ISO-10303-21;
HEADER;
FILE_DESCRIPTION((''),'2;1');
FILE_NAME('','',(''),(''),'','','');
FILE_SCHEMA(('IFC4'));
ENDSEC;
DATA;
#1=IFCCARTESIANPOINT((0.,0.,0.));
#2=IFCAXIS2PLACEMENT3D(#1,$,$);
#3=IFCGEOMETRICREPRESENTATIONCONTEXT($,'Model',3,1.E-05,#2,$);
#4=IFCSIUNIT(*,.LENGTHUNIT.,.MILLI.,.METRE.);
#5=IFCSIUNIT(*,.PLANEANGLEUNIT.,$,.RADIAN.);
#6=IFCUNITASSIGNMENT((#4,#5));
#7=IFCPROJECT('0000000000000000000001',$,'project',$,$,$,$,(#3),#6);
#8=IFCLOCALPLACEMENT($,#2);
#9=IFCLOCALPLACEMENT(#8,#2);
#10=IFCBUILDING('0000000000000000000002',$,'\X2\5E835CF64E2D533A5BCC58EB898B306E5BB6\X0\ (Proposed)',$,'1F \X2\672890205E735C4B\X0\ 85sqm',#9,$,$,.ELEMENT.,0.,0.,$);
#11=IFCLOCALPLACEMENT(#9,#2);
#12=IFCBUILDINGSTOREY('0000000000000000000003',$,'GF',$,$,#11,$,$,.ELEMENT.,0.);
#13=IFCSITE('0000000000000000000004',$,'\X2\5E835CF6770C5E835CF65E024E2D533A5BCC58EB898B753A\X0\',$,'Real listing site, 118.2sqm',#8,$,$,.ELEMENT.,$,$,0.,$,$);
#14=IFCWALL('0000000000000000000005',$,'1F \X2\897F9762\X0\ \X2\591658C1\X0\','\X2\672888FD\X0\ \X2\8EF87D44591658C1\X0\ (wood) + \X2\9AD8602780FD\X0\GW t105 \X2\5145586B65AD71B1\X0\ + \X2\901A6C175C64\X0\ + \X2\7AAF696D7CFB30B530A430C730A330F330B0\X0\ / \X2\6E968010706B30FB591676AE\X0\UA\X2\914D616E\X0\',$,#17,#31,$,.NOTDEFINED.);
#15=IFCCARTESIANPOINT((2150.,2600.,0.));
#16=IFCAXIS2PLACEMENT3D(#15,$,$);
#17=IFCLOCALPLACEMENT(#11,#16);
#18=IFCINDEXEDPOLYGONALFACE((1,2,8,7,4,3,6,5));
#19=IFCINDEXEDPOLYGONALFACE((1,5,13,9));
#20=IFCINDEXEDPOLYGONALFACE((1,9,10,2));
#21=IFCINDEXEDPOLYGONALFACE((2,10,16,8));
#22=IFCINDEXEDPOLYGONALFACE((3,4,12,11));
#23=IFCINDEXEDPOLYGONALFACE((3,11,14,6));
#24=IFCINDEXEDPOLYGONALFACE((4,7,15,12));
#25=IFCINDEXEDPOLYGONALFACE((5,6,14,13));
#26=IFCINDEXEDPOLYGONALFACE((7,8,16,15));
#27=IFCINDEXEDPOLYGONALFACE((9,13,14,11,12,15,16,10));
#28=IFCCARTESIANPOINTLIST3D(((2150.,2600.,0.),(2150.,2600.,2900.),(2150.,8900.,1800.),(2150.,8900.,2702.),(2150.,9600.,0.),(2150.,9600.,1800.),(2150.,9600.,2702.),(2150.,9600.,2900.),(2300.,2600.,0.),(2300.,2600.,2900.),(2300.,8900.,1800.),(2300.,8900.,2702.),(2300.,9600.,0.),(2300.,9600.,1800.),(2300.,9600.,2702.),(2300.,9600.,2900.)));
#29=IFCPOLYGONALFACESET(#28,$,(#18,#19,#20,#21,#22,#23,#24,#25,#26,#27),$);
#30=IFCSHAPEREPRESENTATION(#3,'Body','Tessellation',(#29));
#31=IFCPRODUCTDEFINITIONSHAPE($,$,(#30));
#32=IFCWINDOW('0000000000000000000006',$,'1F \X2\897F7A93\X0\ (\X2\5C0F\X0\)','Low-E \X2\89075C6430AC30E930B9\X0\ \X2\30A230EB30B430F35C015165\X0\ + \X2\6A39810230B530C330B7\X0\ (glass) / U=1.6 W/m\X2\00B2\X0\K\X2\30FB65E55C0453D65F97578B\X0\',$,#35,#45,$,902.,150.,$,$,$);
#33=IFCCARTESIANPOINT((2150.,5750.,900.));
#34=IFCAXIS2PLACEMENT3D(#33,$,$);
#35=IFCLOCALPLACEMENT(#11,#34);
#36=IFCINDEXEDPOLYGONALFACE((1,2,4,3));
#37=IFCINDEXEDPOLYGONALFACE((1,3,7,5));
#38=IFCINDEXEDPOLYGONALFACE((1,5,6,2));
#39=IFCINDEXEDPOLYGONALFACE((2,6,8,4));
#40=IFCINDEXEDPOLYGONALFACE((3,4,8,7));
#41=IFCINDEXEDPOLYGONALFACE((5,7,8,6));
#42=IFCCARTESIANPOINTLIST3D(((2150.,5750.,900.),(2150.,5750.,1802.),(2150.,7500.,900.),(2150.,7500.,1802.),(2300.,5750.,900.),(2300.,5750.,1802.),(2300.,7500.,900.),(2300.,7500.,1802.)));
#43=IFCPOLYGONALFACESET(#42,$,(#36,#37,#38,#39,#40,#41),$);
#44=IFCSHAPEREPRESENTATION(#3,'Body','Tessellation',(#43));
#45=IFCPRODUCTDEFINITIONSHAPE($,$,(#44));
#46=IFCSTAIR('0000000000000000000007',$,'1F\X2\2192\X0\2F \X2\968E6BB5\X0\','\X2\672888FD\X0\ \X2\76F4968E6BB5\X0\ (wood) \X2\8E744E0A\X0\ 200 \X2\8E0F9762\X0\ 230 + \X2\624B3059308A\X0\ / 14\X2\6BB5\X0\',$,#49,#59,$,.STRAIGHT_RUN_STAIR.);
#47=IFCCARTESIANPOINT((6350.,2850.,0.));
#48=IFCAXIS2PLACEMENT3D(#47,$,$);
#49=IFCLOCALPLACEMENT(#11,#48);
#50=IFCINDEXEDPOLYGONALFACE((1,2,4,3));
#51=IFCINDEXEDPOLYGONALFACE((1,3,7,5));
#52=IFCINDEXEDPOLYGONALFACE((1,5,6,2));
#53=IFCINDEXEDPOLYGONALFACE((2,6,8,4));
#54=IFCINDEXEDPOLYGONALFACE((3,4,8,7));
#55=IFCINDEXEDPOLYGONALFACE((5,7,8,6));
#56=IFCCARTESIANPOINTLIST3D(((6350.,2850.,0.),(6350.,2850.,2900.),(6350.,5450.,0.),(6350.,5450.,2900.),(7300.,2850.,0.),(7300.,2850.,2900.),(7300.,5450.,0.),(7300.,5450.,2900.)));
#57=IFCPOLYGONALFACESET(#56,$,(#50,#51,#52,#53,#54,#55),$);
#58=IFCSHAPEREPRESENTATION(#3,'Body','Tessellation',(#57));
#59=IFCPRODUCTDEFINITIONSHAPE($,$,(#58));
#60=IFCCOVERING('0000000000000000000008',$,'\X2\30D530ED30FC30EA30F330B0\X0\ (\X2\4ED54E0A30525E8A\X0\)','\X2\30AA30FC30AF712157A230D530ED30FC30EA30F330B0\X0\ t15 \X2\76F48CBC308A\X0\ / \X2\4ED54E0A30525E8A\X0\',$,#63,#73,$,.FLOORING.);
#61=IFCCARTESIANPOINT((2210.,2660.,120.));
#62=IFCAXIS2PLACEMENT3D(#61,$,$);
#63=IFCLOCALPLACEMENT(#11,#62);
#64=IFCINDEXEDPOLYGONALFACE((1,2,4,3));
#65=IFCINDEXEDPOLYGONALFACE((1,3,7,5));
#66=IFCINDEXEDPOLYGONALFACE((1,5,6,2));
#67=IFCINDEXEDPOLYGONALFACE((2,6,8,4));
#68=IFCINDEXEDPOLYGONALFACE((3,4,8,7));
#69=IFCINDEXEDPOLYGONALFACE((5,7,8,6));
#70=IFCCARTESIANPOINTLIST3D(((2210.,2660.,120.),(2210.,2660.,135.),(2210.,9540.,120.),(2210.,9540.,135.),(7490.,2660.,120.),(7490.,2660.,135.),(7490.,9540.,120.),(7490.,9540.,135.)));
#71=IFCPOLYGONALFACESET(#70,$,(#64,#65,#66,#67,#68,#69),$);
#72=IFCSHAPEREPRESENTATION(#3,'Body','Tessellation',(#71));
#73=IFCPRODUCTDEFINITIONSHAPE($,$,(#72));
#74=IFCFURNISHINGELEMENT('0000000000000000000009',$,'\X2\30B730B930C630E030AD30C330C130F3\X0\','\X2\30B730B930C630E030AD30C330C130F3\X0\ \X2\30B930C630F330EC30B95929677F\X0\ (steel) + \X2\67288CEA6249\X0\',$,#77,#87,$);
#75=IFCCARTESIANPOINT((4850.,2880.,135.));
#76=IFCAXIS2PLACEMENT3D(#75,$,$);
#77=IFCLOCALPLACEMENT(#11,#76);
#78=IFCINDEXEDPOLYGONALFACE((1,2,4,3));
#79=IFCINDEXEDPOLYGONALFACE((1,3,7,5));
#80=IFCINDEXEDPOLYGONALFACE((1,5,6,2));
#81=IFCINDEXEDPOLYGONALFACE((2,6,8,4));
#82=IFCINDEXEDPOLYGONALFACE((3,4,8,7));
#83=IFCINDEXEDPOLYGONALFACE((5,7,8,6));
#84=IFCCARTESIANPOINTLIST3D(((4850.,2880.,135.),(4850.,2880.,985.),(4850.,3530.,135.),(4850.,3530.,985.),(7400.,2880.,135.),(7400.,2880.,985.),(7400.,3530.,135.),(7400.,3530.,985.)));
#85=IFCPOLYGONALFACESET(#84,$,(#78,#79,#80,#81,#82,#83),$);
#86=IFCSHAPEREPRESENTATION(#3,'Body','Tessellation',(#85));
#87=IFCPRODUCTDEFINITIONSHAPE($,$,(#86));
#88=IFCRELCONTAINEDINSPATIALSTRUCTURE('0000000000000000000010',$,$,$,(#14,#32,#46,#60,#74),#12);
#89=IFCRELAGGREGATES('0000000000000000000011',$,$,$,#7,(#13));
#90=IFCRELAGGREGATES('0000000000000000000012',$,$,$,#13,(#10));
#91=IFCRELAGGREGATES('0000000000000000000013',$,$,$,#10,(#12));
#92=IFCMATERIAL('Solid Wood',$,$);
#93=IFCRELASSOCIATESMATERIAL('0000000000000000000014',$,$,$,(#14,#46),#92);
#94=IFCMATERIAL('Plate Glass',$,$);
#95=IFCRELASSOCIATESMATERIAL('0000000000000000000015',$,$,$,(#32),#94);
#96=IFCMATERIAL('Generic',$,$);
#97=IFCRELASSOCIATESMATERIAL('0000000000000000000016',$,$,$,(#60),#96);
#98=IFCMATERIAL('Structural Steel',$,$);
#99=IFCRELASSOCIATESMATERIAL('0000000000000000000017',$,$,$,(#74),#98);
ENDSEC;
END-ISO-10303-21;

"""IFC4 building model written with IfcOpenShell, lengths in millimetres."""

from ifc_helpers import new_model, si_unit, frame, frame_2d, origin, place, context, project, spatial, rectangle, extrude, material, element, fill, save


model = new_model("IFC4")

# Units and contexts
model_context = context("Model", 3, precision=1e-05, world=origin())
ifc_project = project(units=[si_unit("LENGTHUNIT", "METRE", prefix="MILLI"), si_unit("PLANEANGLEUNIT", "RADIAN")], contexts=[model_context])

# Site, building, storey
site_placement = place(None, origin())
site = spatial("IfcSite", under=ifc_project, at=site_placement, Name="広島県広島市中区富士見町", ObjectType="Real listing site, 118.2sqm", CompositionType="ELEMENT", RefElevation=0.0)
building_placement = place(site_placement, origin())
building = spatial("IfcBuilding", under=site, at=building_placement, Name="広島中区富士見の家 (Proposed)", ObjectType="1F 木造平屋 85sqm", CompositionType="ELEMENT", ElevationOfRefHeight=0.0, ElevationOfTerrain=0.0)
storey_placement = place(building_placement, origin())
storey = spatial("IfcBuildingStorey", under=building, at=storey_placement, Name="GF", CompositionType="ELEMENT", Elevation=0.0)

# Shared definitions
ifc_material_1 = material(Name="Solid Wood")
ifc_material_2 = material(Name="Generic")

# Shared definitions
ifc_material_3 = material(Name="Plate Glass")

# Wall, opening, window
wall_1_placement = place(storey_placement, frame((2150.0, 2600.0, 0.0)))
wall_1 = element("IfcWall", 1, at=wall_1_placement, inside=storey, material=ifc_material_1, Name="1F 西面 外壁", Description="木製 軸組外壁 (wood) + 高性能GW t105 充填断熱 + 通気層 + 窯業系サイディング / 準耐火・外皮UA配慮", PredefinedType="NOTDEFINED", context=model_context, shape_type="SweptSolid", body=[
    extrude(rectangle(XDim=150.0, YDim=7000.0, at=frame_2d((75.0, 3500.0))), frame((2150.0, 2600.0, 0.0)), (0.0, 0.0, 1.0), 2900.0),
])
opening_1_placement = place(storey_placement, frame((2150.0, 5750.0, 900.0)))
opening_1 = element("IfcOpeningElement", 2, at=opening_1_placement, cuts=wall_1, PredefinedType="NOTDEFINED", context=model_context, shape_type="SweptSolid", body=[
    extrude(rectangle(XDim=150.0, YDim=1750.0, at=frame_2d((75.0, 875.0))), frame((2150.0, 5750.0, 900.0)), (0.0, 0.0, 1.0), 902.0),
])
window_1_placement = place(storey_placement, frame((2150.0, 5750.0, 900.0)))
window_1 = element("IfcWindow", 3, at=window_1_placement, inside=storey, material=ifc_material_3, Name="1F 西窓 (小)", Description="Low-E 複層ガラス アルゴン封入 + 樹脂サッシ (glass) / U=1.6 W/m²K・日射取得型", OverallHeight=902.0, OverallWidth=150.0, context=model_context, shape_type="SweptSolid", body=[
    extrude(rectangle(XDim=150.0, YDim=1750.0, at=frame_2d((75.0, 875.0))), frame((2150.0, 5750.0, 900.0)), (0.0, 0.0, 1.0), 902.0),
])
fill(opening_1, window_1)

# Stair
stair_placement = place(storey_placement, frame((6350.0, 2850.0, 0.0)))
element("IfcStair", 4, at=stair_placement, inside=storey, material=ifc_material_1, Name="1F→2F 階段", Description="木製 直階段 (wood) 蹴上 200 踏面 230 + 手すり / 14段", PredefinedType="STRAIGHT_RUN_STAIR", context=model_context, shape_type="SweptSolid", body=[
    extrude(rectangle(XDim=950.0, YDim=2600.0, at=frame_2d((475.0, 1300.0))), frame((6350.0, 2850.0, 0.0)), (0.0, 0.0, 1.0), 2900.0),
])

# Covering
covering_placement = place(storey_placement, frame((2210.0, 2660.0, 120.0)))
element("IfcCovering", 5, at=covering_placement, inside=storey, material=ifc_material_2, Name="フローリング (仕上げ床)", Description="オーク無垢フローリング t15 直貼り / 仕上げ床", PredefinedType="FLOORING", context=model_context, shape_type="SweptSolid", body=[
    extrude(rectangle(XDim=5280.0, YDim=6880.0, at=frame_2d((2640.0, 3440.0))), frame((2210.0, 2660.0, 120.0)), (0.0, 0.0, 1.0), 15.0),
])

# Furnishing element
ifc_material_4 = material(Name="Structural Steel")
furnishing_placement = place(storey_placement, frame((4850.0, 2880.0, 135.0)))
element("IfcFurnishingElement", 6, at=furnishing_placement, inside=storey, material=ifc_material_4, Name="システムキッチン", Description="システムキッチン ステンレス天板 (steel) + 木質扉", context=model_context, shape_type="SweptSolid", body=[
    extrude(rectangle(XDim=2550.0, YDim=650.0, at=frame_2d((1275.0, 325.0))), frame((4850.0, 2880.0, 135.0)), (0.0, 0.0, 1.0), 850.0),
])

save(model, "model.ifc")
